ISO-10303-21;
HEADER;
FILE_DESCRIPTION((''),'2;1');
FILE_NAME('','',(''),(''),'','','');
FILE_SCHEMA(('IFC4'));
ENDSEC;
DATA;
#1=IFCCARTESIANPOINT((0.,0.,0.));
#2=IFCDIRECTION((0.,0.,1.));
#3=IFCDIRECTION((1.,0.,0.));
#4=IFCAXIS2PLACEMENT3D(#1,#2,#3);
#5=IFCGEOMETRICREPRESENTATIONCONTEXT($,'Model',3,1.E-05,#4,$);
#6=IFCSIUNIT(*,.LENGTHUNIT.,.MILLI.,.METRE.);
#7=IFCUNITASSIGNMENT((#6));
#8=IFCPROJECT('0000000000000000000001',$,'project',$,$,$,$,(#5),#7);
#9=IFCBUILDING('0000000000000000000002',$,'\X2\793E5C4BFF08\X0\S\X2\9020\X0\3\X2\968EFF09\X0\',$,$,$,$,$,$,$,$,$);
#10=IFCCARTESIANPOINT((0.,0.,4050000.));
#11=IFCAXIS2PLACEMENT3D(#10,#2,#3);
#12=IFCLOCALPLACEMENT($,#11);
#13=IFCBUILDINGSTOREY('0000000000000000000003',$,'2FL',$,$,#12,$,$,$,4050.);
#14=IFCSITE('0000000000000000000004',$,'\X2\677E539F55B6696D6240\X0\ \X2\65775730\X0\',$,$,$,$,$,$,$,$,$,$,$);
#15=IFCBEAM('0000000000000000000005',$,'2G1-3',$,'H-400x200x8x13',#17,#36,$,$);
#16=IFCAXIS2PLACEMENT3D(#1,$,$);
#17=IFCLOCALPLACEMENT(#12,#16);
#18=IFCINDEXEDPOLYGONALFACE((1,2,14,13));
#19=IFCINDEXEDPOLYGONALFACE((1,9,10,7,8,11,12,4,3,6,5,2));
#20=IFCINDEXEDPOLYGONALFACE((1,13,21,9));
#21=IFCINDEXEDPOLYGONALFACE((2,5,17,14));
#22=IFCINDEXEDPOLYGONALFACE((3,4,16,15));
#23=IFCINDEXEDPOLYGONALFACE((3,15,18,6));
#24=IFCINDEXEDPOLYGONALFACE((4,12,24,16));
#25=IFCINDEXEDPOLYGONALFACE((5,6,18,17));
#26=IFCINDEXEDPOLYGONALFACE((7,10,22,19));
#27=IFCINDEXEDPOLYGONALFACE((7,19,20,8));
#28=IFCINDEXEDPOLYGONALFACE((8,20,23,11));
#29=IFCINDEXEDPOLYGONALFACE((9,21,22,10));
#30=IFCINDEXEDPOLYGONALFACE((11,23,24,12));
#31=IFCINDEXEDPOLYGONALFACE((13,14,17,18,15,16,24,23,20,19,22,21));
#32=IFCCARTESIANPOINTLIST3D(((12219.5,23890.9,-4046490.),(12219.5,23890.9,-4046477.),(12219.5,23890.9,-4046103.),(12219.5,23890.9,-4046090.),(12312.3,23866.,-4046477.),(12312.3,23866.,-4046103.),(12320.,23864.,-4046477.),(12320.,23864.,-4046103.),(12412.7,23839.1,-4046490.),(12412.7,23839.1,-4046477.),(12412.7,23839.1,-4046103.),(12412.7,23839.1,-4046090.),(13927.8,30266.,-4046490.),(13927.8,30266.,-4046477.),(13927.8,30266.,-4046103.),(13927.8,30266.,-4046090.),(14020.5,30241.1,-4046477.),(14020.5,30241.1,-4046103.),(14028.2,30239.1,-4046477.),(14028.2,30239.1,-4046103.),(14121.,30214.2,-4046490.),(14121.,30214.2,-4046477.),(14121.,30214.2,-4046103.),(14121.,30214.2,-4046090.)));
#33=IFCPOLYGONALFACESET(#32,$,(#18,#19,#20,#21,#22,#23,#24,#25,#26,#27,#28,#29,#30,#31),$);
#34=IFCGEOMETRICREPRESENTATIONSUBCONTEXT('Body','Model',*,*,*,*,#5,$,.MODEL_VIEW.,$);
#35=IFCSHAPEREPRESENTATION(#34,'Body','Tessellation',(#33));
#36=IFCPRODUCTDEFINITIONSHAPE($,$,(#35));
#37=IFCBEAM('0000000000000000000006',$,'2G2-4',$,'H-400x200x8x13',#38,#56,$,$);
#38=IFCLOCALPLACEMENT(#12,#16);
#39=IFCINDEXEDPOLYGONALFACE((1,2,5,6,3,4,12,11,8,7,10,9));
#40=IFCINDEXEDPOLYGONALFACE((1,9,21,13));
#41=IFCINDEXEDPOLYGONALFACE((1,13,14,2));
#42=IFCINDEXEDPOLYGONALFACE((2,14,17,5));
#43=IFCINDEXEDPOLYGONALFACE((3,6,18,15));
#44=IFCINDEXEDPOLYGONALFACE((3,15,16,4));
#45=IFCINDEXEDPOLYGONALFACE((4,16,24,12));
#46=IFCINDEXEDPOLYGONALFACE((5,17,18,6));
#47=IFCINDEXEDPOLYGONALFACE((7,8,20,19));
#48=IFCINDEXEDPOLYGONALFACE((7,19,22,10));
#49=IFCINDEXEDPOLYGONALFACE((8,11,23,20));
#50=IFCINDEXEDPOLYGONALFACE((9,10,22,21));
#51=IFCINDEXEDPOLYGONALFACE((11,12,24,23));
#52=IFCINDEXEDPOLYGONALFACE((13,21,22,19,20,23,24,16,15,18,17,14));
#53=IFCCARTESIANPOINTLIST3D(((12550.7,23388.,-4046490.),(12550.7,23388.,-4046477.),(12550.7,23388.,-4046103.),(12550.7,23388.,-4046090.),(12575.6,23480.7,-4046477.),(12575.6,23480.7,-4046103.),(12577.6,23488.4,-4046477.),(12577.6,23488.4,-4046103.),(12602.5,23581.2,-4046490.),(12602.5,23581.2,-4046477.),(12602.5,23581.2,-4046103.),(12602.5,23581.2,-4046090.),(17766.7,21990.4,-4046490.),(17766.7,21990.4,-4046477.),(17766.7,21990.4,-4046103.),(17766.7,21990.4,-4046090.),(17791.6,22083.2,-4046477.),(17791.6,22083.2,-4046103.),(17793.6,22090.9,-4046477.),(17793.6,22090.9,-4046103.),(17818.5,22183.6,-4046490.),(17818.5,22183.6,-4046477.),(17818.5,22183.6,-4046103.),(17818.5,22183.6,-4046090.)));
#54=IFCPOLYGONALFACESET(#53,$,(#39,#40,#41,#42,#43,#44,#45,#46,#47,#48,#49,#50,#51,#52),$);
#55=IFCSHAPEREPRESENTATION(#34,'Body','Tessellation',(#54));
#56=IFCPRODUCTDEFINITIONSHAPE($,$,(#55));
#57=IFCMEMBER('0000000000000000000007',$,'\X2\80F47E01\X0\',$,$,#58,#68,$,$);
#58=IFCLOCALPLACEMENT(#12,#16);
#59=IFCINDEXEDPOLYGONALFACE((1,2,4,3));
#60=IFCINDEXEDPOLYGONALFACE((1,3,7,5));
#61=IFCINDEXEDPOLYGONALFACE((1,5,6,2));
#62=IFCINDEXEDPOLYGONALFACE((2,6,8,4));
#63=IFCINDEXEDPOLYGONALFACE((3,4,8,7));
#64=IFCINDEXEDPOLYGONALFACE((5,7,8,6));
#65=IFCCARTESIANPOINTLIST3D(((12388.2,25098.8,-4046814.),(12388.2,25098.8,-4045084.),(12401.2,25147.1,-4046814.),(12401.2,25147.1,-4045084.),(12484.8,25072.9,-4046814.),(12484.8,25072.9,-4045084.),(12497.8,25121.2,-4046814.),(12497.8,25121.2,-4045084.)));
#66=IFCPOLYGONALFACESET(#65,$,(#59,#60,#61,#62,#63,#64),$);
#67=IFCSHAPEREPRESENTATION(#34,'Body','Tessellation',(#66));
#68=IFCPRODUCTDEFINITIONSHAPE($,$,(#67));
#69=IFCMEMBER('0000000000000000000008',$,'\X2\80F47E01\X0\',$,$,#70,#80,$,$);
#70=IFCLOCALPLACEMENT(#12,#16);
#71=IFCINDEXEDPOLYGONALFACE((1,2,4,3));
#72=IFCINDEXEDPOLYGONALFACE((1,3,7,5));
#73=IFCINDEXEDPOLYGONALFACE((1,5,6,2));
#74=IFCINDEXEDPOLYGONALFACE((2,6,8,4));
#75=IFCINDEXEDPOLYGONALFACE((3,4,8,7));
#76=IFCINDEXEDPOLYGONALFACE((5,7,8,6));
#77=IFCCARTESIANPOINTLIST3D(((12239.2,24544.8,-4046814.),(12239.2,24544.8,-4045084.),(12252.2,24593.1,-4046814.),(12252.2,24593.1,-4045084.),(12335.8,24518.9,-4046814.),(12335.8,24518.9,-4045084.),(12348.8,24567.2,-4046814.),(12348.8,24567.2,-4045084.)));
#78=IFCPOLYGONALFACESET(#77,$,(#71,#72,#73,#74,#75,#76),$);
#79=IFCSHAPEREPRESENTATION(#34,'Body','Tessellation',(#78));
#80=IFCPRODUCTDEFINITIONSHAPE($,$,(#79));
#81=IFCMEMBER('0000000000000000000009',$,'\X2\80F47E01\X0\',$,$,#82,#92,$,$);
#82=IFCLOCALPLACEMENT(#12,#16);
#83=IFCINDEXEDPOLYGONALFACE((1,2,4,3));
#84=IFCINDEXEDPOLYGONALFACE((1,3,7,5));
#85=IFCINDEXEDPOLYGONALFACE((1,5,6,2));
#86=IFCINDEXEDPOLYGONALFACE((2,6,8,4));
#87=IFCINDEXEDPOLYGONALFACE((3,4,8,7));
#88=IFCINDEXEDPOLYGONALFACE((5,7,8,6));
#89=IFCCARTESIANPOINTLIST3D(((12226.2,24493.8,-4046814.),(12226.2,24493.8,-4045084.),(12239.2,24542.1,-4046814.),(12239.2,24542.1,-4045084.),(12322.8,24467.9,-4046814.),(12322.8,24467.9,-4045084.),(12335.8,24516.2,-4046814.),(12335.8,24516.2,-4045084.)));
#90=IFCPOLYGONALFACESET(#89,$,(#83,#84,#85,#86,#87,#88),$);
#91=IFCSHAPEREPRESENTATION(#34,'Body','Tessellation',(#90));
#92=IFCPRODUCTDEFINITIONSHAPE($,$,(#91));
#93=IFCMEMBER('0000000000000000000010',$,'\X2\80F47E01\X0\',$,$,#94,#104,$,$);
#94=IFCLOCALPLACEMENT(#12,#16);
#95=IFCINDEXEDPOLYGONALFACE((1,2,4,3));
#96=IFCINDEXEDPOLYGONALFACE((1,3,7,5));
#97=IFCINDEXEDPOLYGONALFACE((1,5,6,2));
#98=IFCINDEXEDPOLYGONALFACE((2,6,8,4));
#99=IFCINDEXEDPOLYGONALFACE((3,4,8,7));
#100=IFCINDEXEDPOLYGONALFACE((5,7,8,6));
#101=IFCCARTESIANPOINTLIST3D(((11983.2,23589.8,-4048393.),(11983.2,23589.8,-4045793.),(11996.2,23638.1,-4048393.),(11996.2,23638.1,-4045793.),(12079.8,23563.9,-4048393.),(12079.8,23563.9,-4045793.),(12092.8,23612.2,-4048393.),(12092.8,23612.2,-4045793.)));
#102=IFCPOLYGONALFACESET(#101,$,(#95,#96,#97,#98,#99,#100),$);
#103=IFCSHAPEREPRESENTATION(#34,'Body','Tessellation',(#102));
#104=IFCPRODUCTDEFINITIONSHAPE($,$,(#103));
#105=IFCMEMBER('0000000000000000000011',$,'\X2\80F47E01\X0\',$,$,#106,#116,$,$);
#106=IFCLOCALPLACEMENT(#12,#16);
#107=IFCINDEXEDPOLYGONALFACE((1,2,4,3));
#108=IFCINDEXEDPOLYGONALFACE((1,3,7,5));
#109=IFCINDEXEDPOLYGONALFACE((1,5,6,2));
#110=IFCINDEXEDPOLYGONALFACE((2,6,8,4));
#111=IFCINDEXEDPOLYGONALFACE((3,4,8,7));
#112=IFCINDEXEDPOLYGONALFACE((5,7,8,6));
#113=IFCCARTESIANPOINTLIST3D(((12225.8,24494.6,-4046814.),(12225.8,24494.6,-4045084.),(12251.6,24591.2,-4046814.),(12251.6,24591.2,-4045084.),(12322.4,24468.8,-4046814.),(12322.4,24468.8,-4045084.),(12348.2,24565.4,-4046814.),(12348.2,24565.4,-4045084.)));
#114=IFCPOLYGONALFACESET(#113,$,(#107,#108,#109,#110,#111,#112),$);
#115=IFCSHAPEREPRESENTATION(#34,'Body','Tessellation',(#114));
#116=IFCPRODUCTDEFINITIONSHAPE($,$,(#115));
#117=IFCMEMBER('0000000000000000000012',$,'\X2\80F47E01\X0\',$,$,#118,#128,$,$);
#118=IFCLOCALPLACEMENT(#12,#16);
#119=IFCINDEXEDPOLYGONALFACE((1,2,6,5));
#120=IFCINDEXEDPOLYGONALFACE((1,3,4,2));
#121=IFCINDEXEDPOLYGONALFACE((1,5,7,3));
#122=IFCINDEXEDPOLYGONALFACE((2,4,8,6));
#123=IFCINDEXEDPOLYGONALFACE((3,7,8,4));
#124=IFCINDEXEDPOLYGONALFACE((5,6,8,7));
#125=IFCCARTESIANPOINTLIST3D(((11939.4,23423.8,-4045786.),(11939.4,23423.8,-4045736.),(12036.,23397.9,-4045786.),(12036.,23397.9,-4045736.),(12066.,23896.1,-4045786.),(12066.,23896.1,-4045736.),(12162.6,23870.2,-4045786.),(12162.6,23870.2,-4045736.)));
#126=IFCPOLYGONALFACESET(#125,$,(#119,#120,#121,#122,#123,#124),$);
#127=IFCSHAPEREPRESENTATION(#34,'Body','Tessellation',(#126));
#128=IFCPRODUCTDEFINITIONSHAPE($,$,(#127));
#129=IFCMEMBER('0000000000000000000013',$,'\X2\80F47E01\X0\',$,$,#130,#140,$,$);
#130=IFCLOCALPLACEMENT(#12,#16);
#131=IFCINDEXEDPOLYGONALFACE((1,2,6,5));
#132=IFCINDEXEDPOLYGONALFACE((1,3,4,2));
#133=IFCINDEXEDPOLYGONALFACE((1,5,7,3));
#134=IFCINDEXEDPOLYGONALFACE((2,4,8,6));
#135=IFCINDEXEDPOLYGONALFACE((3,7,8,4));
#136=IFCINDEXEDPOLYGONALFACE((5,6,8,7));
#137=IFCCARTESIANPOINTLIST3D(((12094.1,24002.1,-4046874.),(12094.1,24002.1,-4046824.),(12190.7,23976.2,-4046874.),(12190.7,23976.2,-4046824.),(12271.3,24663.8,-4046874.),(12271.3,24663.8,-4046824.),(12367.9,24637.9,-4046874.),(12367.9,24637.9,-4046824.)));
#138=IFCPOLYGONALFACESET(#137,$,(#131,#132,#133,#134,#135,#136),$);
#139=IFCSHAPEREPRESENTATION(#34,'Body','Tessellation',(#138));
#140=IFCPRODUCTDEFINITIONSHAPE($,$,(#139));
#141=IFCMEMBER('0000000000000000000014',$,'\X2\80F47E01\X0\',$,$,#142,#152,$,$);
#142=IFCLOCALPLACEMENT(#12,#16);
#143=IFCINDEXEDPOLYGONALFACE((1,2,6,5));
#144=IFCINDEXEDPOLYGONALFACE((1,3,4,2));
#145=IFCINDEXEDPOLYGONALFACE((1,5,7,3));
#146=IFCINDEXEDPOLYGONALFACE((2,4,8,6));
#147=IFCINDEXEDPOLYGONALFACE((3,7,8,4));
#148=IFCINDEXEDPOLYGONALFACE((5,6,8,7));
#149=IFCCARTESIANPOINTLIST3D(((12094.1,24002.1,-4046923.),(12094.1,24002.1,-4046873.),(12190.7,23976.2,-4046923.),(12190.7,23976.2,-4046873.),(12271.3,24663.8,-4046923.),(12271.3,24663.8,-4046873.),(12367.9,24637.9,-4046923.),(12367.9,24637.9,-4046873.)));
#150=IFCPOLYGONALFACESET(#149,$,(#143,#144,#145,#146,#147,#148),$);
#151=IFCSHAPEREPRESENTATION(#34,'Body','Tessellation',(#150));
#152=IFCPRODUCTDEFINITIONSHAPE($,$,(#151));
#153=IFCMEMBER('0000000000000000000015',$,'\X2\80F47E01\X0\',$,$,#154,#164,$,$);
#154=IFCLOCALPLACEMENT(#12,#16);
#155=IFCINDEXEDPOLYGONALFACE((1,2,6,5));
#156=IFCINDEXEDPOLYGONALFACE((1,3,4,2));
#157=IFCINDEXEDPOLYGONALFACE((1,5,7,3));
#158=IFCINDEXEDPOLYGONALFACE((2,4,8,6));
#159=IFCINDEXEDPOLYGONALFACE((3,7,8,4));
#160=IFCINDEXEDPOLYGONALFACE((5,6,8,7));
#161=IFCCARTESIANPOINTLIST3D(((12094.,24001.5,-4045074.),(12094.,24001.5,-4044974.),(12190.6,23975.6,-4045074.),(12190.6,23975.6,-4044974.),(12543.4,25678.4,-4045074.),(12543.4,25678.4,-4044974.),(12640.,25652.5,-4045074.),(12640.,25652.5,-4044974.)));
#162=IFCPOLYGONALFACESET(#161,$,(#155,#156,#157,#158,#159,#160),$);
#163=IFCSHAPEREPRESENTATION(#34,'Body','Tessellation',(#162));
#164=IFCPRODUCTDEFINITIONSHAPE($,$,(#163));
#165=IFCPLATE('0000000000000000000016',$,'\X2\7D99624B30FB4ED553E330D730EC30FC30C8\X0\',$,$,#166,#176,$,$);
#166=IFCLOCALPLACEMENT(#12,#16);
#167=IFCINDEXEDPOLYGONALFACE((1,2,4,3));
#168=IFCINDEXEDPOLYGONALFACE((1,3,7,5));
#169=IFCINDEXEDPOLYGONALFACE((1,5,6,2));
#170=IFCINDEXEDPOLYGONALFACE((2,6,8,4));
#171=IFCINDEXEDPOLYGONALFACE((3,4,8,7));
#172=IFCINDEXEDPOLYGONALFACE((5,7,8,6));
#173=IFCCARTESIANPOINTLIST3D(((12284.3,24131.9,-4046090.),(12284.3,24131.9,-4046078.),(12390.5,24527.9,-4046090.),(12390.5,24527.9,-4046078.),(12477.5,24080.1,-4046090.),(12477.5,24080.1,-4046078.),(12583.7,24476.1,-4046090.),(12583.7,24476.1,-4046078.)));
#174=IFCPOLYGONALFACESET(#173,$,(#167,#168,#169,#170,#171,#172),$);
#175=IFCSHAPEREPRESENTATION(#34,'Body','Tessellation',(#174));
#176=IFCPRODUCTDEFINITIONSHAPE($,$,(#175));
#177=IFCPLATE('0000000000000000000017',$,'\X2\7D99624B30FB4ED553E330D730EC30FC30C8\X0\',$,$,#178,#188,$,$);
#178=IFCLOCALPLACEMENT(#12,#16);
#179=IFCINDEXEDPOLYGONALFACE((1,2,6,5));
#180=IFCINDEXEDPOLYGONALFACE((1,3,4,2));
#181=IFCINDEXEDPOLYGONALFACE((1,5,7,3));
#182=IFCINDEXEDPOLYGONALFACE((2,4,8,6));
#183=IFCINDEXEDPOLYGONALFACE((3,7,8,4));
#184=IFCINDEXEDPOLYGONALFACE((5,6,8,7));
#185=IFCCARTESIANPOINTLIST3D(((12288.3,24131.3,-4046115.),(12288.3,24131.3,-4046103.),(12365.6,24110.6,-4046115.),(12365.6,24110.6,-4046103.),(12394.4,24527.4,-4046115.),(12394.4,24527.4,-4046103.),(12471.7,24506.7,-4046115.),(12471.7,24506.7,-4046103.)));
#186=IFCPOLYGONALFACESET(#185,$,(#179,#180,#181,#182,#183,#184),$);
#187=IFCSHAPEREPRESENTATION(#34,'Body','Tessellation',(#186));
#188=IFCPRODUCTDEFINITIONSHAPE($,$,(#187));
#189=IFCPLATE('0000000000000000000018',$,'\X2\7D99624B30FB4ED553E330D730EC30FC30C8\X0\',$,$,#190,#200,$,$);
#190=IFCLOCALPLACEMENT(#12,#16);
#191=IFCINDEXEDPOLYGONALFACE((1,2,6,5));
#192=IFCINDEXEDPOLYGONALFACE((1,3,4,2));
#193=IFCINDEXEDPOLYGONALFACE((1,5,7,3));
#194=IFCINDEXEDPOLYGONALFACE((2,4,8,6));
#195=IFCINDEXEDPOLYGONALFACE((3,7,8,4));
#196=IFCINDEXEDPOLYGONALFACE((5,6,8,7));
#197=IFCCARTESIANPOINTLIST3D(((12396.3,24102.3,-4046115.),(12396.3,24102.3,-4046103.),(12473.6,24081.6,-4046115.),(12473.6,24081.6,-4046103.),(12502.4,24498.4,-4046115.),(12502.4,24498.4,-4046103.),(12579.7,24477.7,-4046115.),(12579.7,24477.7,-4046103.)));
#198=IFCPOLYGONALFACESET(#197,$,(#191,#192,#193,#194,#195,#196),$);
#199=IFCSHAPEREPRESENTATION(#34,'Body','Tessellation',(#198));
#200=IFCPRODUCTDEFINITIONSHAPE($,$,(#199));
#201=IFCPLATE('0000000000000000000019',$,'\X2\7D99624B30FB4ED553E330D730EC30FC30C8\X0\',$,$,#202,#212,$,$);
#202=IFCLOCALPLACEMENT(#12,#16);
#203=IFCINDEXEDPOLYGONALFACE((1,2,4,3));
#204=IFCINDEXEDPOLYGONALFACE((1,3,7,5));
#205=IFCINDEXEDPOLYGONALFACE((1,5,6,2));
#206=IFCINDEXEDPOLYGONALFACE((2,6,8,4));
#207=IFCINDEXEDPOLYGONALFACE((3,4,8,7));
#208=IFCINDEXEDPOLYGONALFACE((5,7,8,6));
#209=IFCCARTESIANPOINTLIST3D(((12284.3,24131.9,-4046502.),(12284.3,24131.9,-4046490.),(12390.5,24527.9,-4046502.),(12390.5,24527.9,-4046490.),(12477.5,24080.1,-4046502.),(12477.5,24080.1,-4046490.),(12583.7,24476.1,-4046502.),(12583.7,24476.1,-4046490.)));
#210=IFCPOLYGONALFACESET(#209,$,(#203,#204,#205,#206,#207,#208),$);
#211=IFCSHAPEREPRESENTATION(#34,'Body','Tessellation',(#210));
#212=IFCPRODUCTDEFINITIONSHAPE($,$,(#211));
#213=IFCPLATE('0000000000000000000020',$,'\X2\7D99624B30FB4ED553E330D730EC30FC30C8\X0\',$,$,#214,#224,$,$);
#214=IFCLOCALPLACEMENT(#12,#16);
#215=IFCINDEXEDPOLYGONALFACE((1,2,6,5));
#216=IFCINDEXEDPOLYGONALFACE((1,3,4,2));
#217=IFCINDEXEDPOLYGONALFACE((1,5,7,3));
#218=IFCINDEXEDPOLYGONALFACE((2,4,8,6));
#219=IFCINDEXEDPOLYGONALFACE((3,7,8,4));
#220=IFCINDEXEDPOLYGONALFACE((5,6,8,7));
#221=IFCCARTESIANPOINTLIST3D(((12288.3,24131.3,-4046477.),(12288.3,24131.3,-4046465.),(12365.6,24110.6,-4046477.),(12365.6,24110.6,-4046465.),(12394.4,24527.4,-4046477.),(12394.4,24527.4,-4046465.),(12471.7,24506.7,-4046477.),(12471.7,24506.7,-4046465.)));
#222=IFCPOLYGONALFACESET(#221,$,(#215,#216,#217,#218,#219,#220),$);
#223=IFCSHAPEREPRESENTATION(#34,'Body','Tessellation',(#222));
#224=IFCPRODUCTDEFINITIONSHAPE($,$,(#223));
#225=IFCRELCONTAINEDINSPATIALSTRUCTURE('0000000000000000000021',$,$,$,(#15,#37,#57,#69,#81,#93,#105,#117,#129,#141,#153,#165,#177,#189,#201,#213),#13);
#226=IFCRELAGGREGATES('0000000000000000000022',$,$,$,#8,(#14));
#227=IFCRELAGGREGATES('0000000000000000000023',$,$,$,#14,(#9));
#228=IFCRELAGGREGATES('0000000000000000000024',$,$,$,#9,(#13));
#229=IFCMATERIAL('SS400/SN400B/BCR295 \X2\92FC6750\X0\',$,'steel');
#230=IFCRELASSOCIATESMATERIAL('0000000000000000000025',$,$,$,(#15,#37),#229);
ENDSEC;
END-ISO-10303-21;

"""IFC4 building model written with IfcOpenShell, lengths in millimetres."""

from ifc_helpers import new_model, si_unit, frame, origin, origin_with_axes, place, context, subcontext, project, spatial, rectangle, i_section, extrude, material, element, save


model = new_model("IFC4")

# Units and contexts
model_context = context("Model", 3, precision=1e-05, world=origin_with_axes())
body_context = subcontext(model_context, "Body", "Model", "MODEL_VIEW")
ifc_project = project(units=[si_unit("LENGTHUNIT", "METRE", prefix="MILLI")], contexts=[model_context])

# Site, building, storey
site = spatial("IfcSite", under=ifc_project, Name="松原営業所 敷地")
building = spatial("IfcBuilding", under=site, Name="社屋（S造3階）")
storey_placement = place(None, frame((0.0, 0.0, 4050000.0), z_axis=(0.0, 0.0, 1.0), x_axis=(1.0, 0.0, 0.0)))
storey = spatial("IfcBuildingStorey", under=building, at=storey_placement, Name="2FL", Elevation=4050.0)

# Beams
ifc_material = material(Name="SS400/SN400B/BCR295 鋼材", Category="steel")
beam_1_placement = place(storey_placement, frame((12316.1, 23865.0, -4046090.0), z_axis=(0.258825, 0.965924, 0.0), x_axis=(-0.965924, 0.258825, 0.0)))
element("IfcBeam", 1, at=beam_1_placement, inside=storey, material=ifc_material, Name="2G1-3", ObjectType="H-400x200x8x13", context=body_context, shape_type="SweptSolid", body=[
    extrude(i_section(OverallWidth=200.0, OverallDepth=400.0, WebThickness=8.0, FlangeThickness=13.0), frame((0.0, -200.0, 0.0)), (0.0, 0.0, 1.0), 6600.0),
])
beam_2_placement = place(storey_placement, frame((12576.6, 23484.6, -4046090.0), z_axis=(0.965929, -0.258807, 0.0), x_axis=(0.258807, 0.965929, 0.0)))
element("IfcBeam", 2, at=beam_2_placement, inside=storey, material=ifc_material, Name="2G2-4", ObjectType="H-400x200x8x13", context=body_context, shape_type="SweptSolid", body=[
    extrude(i_section(OverallWidth=200.0, OverallDepth=400.0, WebThickness=8.0, FlangeThickness=13.0), frame((0.0, -200.0, 0.0)), (0.0, 0.0, 1.0), 5400.0),
])

# Members
for number, where, z_axis, x_axis, name in (
    (3, (12449.5, 25134.1, -4045949.0), (-0.258819, -0.965926, 0.0), (0.965926, -0.258819, 0.0), "胴縁"),
    (4, (12300.5, 24580.1, -4045949.0), (-0.258819, -0.965926, 0.0), (0.965926, -0.258819, 0.0), "胴縁"),
    (5, (12287.5, 24529.1, -4045949.0), (-0.258819, -0.965926, 0.0), (0.965926, -0.258819, 0.0), "胴縁"),
):
    element("IfcMember", number, at=place(storey_placement, frame(where, z_axis=z_axis, x_axis=x_axis)), inside=storey, Name=name, context=body_context, shape_type="SweptSolid", body=[
        extrude(rectangle(XDim=100.0, YDim=1730.0), origin(), (0.0, 0.0, 1.0), 50.0),
    ])
member_1_placement = place(storey_placement, frame((12044.5, 23625.1, -4047093.0), z_axis=(-0.258819, -0.965926, 0.0), x_axis=(0.965926, -0.258819, 0.0)))
element("IfcMember", 6, at=member_1_placement, inside=storey, Name="胴縁", context=body_context, shape_type="SweptSolid", body=[
    extrude(rectangle(XDim=100.0, YDim=2600.0), origin(), (0.0, 0.0, 1.0), 50.0),
])
member_2_placement = place(storey_placement, frame((12299.9, 24578.3, -4045949.0), z_axis=(-0.258819, -0.965926, 0.0), x_axis=(0.965926, -0.258819, 0.0)))
element("IfcMember", 7, at=member_2_placement, inside=storey, Name="胴縁", context=body_context, shape_type="SweptSolid", body=[
    extrude(rectangle(XDim=100.0, YDim=1730.0), origin(), (0.0, 0.0, 1.0), 100.0),
])
member_3_placement = place(storey_placement, frame((12114.3, 23883.2, -4045761.0), z_axis=(-0.258819, -0.965926, 0.0), x_axis=(0.965926, -0.258819, 0.0)))
element("IfcMember", 8, at=member_3_placement, inside=storey, Name="胴縁", context=body_context, shape_type="SweptSolid", body=[
    extrude(rectangle(XDim=100.0, YDim=50.0), origin(), (0.0, 0.0, 1.0), 489.0),
])
for number, where, z_axis, x_axis, name in (
    (9, (12319.6, 24650.8, -4046849.0), (-0.258819, -0.965926, 0.0), (0.965926, -0.258819, 0.0), "胴縁"),
    (10, (12319.6, 24650.8, -4046898.0), (-0.258819, -0.965926, 0.0), (0.965926, -0.258819, 0.0), "胴縁"),
):
    element("IfcMember", number, at=place(storey_placement, frame(where, z_axis=z_axis, x_axis=x_axis)), inside=storey, Name=name, context=body_context, shape_type="SweptSolid", body=[
        extrude(rectangle(XDim=100.0, YDim=50.0), origin(), (0.0, 0.0, 1.0), 685.0),
    ])
member_4_placement = place(storey_placement, frame((12591.7, 25665.4, -4045024.0), z_axis=(-0.258819, -0.965926, 0.0), x_axis=(0.965926, -0.258819, 0.0)))
element("IfcMember", 11, at=member_4_placement, inside=storey, Name="胴縁", context=body_context, shape_type="SweptSolid", body=[
    extrude(rectangle(XDim=100.0, YDim=100.0), origin(), (0.0, 0.0, 1.0), 1736.0),
])

# Plates
plate_1_placement = place(storey_placement, frame((12380.9, 24106.0, -4046084.0), z_axis=(0.258819, 0.965926, 0.0), x_axis=(-0.965926, 0.258819, 0.0)))
element("IfcPlate", 12, at=plate_1_placement, inside=storey, Name="継手・仕口プレート", context=body_context, shape_type="SweptSolid", body=[
    extrude(rectangle(XDim=200.0, YDim=12.0), origin(), (0.0, 0.0, 1.0), 410.0),
])
for number, where, z_axis, x_axis, name in (
    (13, (12326.9, 24121.0, -4046109.0), (0.258819, 0.965926, 0.0), (-0.965926, 0.258819, 0.0), "継手・仕口プレート"),
    (14, (12434.9, 24092.0, -4046109.0), (0.258819, 0.965926, 0.0), (-0.965926, 0.258819, 0.0), "継手・仕口プレート"),
):
    element("IfcPlate", number, at=place(storey_placement, frame(where, z_axis=z_axis, x_axis=x_axis)), inside=storey, Name=name, context=body_context, shape_type="SweptSolid", body=[
        extrude(rectangle(XDim=80.0, YDim=12.0), origin(), (0.0, 0.0, 1.0), 410.0),
    ])
plate_2_placement = place(storey_placement, frame((12380.9, 24106.0, -4046496.0), z_axis=(0.258819, 0.965926, 0.0), x_axis=(-0.965926, 0.258819, 0.0)))
element("IfcPlate", 15, at=plate_2_placement, inside=storey, Name="継手・仕口プレート", context=body_context, shape_type="SweptSolid", body=[
    extrude(rectangle(XDim=200.0, YDim=12.0), origin(), (0.0, 0.0, 1.0), 410.0),
])
for number, where, z_axis, x_axis, name in (
    (16, (12326.9, 24121.0, -4046471.0), (0.258819, 0.965926, 0.0), (-0.965926, 0.258819, 0.0), "継手・仕口プレート"),
):
    element("IfcPlate", number, at=place(storey_placement, frame(where, z_axis=z_axis, x_axis=x_axis)), inside=storey, Name=name, context=body_context, shape_type="SweptSolid", body=[
        extrude(rectangle(XDim=80.0, YDim=12.0), origin(), (0.0, 0.0, 1.0), 410.0),
    ])

save(model, "model.ifc")
